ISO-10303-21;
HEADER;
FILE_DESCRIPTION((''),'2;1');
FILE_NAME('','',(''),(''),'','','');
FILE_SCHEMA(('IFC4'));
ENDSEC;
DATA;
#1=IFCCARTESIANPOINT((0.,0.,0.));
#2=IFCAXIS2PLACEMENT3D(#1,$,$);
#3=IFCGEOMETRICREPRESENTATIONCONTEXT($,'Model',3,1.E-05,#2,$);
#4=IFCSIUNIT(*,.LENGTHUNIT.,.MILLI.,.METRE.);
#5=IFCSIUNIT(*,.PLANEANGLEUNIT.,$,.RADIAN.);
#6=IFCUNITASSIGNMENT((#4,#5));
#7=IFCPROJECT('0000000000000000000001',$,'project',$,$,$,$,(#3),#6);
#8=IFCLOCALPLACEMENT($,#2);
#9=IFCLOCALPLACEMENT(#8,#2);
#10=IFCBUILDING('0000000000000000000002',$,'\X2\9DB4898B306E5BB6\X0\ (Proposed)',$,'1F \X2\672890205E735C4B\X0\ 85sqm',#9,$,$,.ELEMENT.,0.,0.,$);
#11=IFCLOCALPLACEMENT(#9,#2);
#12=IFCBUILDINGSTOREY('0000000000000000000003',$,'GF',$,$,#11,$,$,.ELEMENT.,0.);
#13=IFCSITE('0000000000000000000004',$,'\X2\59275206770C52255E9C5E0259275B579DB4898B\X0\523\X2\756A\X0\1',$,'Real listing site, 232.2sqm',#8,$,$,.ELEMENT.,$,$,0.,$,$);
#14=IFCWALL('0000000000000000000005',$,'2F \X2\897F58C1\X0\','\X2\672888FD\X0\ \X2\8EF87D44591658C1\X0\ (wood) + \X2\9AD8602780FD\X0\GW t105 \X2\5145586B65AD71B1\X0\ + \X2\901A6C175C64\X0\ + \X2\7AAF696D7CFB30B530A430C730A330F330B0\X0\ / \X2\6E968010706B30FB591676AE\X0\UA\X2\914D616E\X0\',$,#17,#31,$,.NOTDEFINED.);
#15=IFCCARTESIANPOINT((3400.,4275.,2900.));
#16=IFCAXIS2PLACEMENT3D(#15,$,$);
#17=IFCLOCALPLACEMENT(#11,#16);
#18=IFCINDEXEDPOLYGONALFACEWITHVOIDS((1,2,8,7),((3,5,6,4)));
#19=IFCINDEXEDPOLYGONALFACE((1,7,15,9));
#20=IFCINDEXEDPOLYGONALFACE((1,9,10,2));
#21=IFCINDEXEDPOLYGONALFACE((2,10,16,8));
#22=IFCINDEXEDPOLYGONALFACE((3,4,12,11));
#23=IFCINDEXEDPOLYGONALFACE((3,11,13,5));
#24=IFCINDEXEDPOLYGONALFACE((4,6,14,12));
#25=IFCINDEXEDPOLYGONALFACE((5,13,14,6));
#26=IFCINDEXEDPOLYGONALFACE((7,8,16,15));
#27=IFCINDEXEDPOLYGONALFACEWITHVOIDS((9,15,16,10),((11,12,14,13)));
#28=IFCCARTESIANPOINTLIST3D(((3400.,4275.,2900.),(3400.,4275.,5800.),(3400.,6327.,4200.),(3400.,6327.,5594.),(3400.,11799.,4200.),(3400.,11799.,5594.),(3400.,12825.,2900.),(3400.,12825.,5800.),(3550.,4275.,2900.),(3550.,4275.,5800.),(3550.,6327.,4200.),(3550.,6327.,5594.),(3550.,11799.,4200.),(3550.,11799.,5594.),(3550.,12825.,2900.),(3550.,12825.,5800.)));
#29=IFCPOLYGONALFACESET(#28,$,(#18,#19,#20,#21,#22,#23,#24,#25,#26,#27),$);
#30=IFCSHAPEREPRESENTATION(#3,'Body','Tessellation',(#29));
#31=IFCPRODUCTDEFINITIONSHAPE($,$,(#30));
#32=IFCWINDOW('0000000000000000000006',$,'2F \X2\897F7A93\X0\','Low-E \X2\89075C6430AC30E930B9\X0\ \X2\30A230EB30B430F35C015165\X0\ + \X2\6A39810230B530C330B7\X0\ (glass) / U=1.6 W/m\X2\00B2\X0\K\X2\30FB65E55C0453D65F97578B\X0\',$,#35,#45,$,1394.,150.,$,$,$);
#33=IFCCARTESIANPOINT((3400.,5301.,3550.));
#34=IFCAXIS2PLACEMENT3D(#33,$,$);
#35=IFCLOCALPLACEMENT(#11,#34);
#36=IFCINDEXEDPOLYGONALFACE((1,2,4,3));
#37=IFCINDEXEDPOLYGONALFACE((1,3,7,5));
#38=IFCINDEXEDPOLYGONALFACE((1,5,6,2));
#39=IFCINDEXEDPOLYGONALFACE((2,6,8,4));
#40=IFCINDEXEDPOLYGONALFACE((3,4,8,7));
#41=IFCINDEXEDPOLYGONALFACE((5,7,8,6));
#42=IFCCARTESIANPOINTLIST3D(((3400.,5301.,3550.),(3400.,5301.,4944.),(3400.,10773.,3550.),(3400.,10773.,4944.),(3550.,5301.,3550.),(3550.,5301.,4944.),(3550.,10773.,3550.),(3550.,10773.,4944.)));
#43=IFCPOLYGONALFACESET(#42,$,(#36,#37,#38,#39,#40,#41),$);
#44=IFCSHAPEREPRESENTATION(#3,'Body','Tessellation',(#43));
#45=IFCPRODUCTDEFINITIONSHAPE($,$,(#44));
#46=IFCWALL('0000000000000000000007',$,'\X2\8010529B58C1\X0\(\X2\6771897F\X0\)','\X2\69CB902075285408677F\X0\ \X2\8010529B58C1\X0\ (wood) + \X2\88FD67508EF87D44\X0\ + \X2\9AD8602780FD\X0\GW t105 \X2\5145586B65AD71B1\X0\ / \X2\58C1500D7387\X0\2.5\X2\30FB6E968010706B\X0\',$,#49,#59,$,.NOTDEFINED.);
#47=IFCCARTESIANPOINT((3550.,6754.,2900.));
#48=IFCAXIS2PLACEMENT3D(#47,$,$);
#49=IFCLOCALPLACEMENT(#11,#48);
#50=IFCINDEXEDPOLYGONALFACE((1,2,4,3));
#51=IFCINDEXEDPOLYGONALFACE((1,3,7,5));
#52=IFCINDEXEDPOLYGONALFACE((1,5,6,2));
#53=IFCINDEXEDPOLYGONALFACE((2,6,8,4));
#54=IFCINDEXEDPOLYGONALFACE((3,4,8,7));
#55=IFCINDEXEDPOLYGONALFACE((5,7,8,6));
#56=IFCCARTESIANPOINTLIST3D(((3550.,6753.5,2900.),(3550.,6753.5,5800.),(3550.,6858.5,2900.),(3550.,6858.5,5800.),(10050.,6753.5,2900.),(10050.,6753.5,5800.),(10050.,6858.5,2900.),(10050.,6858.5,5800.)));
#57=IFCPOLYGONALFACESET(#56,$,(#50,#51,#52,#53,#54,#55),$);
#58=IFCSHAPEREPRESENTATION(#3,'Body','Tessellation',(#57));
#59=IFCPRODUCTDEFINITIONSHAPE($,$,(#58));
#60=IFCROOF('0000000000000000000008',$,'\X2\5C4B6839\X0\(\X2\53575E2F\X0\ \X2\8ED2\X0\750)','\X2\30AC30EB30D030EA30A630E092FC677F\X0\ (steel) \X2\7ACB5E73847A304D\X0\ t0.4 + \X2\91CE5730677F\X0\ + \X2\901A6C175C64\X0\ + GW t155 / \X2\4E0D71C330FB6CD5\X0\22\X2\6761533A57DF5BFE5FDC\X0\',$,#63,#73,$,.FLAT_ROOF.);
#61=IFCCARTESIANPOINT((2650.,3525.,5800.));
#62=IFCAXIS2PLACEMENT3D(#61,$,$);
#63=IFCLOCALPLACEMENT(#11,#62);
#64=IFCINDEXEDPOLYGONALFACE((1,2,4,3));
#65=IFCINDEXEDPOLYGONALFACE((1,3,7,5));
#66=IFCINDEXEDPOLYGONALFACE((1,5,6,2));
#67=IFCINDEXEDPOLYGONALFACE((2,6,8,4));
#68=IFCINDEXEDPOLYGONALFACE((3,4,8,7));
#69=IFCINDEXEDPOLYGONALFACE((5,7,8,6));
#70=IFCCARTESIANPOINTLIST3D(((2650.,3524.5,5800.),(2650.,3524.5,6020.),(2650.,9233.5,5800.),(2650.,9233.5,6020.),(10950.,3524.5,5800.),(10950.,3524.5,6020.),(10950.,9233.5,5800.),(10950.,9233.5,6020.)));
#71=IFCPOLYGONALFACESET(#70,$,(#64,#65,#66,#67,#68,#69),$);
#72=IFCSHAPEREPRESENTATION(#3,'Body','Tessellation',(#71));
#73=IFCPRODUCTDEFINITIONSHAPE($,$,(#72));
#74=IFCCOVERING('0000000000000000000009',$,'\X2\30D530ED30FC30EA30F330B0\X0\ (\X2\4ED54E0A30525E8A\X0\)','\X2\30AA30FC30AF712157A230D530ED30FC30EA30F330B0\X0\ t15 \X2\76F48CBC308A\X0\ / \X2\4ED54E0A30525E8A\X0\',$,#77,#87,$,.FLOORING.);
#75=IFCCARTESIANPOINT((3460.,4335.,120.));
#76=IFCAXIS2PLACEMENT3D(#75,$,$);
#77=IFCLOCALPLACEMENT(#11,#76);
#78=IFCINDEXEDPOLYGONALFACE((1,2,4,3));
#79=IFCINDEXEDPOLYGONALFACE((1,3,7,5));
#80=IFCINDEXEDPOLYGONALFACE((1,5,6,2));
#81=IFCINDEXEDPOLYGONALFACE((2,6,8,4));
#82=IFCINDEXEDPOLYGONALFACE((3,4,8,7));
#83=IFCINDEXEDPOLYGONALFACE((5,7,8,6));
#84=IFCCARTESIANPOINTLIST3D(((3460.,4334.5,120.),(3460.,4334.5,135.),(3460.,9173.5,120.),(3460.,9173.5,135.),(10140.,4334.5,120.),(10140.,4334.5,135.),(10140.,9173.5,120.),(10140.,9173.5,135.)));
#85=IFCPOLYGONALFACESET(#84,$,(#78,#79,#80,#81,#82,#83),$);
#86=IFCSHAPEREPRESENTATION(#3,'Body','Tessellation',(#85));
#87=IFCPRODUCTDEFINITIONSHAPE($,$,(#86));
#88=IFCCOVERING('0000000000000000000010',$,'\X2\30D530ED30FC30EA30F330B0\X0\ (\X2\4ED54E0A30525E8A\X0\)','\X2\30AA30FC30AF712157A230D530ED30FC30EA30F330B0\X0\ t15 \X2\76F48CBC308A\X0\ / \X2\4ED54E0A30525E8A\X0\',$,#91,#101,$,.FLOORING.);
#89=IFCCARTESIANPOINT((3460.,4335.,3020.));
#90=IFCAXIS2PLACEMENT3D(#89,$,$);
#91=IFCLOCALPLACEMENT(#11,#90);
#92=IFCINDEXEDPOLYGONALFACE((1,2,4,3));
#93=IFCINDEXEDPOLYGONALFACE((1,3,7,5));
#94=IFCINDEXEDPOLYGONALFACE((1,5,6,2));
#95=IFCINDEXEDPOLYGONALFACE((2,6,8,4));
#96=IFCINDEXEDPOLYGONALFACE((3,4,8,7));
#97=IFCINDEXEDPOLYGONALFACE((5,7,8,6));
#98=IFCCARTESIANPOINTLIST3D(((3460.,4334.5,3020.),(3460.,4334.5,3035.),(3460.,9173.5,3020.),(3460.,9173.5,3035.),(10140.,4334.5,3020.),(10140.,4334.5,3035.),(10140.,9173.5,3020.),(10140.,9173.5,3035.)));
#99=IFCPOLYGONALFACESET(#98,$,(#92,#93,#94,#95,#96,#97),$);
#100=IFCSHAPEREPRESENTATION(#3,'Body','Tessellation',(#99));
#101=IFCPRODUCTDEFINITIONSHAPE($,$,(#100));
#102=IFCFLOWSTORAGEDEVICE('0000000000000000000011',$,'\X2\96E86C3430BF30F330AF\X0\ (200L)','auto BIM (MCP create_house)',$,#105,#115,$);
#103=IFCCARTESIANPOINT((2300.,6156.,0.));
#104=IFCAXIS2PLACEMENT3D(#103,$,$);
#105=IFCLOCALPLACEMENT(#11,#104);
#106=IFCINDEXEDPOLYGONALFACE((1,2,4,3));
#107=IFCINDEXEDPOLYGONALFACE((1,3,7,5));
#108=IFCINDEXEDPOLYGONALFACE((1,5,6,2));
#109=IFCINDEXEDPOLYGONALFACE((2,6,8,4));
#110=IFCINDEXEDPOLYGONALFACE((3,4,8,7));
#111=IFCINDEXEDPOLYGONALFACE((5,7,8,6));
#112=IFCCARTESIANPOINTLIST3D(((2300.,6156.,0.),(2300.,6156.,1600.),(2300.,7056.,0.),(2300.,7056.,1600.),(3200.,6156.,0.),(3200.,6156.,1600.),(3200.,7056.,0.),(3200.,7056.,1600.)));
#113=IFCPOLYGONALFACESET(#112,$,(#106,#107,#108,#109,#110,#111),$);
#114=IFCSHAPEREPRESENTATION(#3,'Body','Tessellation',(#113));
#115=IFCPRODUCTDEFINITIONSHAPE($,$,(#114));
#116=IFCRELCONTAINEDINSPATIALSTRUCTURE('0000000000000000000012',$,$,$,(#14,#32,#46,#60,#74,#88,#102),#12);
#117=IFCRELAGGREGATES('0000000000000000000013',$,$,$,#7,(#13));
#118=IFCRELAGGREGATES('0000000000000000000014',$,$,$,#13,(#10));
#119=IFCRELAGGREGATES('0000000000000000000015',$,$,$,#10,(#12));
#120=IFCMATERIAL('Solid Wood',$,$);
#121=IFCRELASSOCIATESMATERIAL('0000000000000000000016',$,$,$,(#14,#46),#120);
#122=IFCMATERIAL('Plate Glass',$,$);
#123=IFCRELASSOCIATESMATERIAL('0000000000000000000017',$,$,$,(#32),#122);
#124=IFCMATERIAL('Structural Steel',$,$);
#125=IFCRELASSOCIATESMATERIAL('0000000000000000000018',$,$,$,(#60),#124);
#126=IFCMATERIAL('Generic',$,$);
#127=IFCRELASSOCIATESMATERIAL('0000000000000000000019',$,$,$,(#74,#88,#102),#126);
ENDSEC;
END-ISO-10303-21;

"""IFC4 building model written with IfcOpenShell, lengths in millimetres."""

from ifc_helpers import new_model, si_unit, frame, frame_2d, origin, place, context, project, spatial, rectangle, extrude, material, element, fill, save


model = new_model("IFC4")

# Units and contexts
model_context = context("Model", 3, precision=1e-05, world=origin())
ifc_project = project(units=[si_unit("LENGTHUNIT", "METRE", prefix="MILLI"), si_unit("PLANEANGLEUNIT", "RADIAN")], contexts=[model_context])

# Site, building, storey
site_placement = place(None, origin())
site = spatial("IfcSite", under=ifc_project, at=site_placement, Name="大分県別府市大字鶴見523番1", ObjectType="Real listing site, 232.2sqm", CompositionType="ELEMENT", RefElevation=0.0)
building_placement = place(site_placement, origin())
building = spatial("IfcBuilding", under=site, at=building_placement, Name="鶴見の家 (Proposed)", ObjectType="1F 木造平屋 85sqm", CompositionType="ELEMENT", ElevationOfRefHeight=0.0, ElevationOfTerrain=0.0)
storey_placement = place(building_placement, origin())
storey = spatial("IfcBuildingStorey", under=building, at=storey_placement, Name="GF", CompositionType="ELEMENT", Elevation=0.0)

# Shared definitions
ifc_material_1 = material(Name="Solid Wood")
ifc_material_2 = material(Name="Generic")

# Shared definitions
ifc_material_3 = material(Name="Plate Glass")

# Wall, opening, window
wall_1_placement = place(storey_placement, frame((3400.0, 4275.0, 2900.0)))
wall_1 = element("IfcWall", 1, at=wall_1_placement, inside=storey, material=ifc_material_1, Name="2F 西壁", Description="木製 軸組外壁 (wood) + 高性能GW t105 充填断熱 + 通気層 + 窯業系サイディング / 準耐火・外皮UA配慮", PredefinedType="NOTDEFINED", context=model_context, shape_type="SweptSolid", body=[
    extrude(rectangle(XDim=150.0, YDim=8550.0, at=frame_2d((75.0, 4275.0))), frame((3400.0, 4275.0, 2900.0)), (0.0, 0.0, 1.0), 2900.0),
])
opening_1_placement = place(storey_placement, frame((3400.0, 5301.0, 3550.0)))
opening_1 = element("IfcOpeningElement", 2, at=opening_1_placement, cuts=wall_1, PredefinedType="NOTDEFINED", context=model_context, shape_type="SweptSolid", body=[
    extrude(rectangle(XDim=150.0, YDim=5472.0, at=frame_2d((75.0, 2736.0))), frame((3400.0, 5301.0, 3550.0)), (0.0, 0.0, 1.0), 1394.0),
])
window_1_placement = place(storey_placement, frame((3400.0, 5301.0, 3550.0)))
window_1 = element("IfcWindow", 3, at=window_1_placement, inside=storey, material=ifc_material_3, Name="2F 西窓", Description="Low-E 複層ガラス アルゴン封入 + 樹脂サッシ (glass) / U=1.6 W/m²K・日射取得型", OverallHeight=1394.0, OverallWidth=150.0, context=model_context, shape_type="SweptSolid", body=[
    extrude(rectangle(XDim=150.0, YDim=5472.0, at=frame_2d((75.0, 2736.0))), frame((3400.0, 5301.0, 3550.0)), (0.0, 0.0, 1.0), 1394.0),
])
fill(opening_1, window_1)

# Wall
wall_2_placement = place(storey_placement, frame((3550.0, 6754.0, 2900.0)))
element("IfcWall", 4, at=wall_2_placement, inside=storey, material=ifc_material_1, Name="耐力壁(東西)", Description="構造用合板 耐力壁 (wood) + 製材軸組 + 高性能GW t105 充填断熱 / 壁倍率2.5・準耐火", PredefinedType="NOTDEFINED", context=model_context, shape_type="SweptSolid", body=[
    extrude(rectangle(XDim=6500.0, YDim=105.0, at=frame_2d((3250.0, 52.0))), frame((3550.0, 6754.0, 2900.0)), (0.0, 0.0, 1.0), 2900.0),
])

# Roof
ifc_material_4 = material(Name="Structural Steel")
for number, where, name in (
    (5, (2650.0, 3525.0, 5800.0), "屋根(南帯 軒750)"),
):
    element("IfcRoof", number, at=place(storey_placement, frame(where)), inside=storey, material=ifc_material_4, Name=name, Description="ガルバリウム鋼板 (steel) 立平葺き t0.4 + 野地板 + 通気層 + GW t155 / 不燃・法22条区域対応", PredefinedType="FLAT_ROOF", context=model_context, shape_type="SweptSolid", body=[
        extrude(rectangle(XDim=8300.0, YDim=5709.0, at=frame_2d((4150.0, 2854.0))), frame((2650.0, 3525.0, 5800.0)), (0.0, 0.0, 1.0), 220.0),
    ])

# Coverings
covering_1_placement = place(storey_placement, frame((3460.0, 4335.0, 120.0)))
element("IfcCovering", 6, at=covering_1_placement, inside=storey, material=ifc_material_2, Name="フローリング (仕上げ床)", Description="オーク無垢フローリング t15 直貼り / 仕上げ床", PredefinedType="FLOORING", context=model_context, shape_type="SweptSolid", body=[
    extrude(rectangle(XDim=6680.0, YDim=4839.0, at=frame_2d((3340.0, 2419.0))), frame((3460.0, 4335.0, 120.0)), (0.0, 0.0, 1.0), 15.0),
])
covering_2_placement = place(storey_placement, frame((3460.0, 4335.0, 3020.0)))
element("IfcCovering", 7, at=covering_2_placement, inside=storey, material=ifc_material_2, Name="フローリング (仕上げ床)", Description="オーク無垢フローリング t15 直貼り / 仕上げ床", PredefinedType="FLOORING", context=model_context, shape_type="SweptSolid", body=[
    extrude(rectangle(XDim=6680.0, YDim=4839.0, at=frame_2d((3340.0, 2419.0))), frame((3460.0, 4335.0, 3020.0)), (0.0, 0.0, 1.0), 15.0),
])

# Flow storage device
flow_storage_device_placement = place(storey_placement, frame((2300.0, 6156.0, 0.0)))
element("IfcFlowStorageDevice", 8, at=flow_storage_device_placement, inside=storey, material=ifc_material_2, Name="雨水タンク (200L)", Description="auto BIM (MCP create_house)", context=model_context, shape_type="SweptSolid", body=[
    extrude(rectangle(XDim=900.0, YDim=900.0, at=frame_2d((450.0, 450.0))), frame((2300.0, 6156.0, 0.0)), (0.0, 0.0, 1.0), 1600.0),
])

save(model, "model.ifc")
